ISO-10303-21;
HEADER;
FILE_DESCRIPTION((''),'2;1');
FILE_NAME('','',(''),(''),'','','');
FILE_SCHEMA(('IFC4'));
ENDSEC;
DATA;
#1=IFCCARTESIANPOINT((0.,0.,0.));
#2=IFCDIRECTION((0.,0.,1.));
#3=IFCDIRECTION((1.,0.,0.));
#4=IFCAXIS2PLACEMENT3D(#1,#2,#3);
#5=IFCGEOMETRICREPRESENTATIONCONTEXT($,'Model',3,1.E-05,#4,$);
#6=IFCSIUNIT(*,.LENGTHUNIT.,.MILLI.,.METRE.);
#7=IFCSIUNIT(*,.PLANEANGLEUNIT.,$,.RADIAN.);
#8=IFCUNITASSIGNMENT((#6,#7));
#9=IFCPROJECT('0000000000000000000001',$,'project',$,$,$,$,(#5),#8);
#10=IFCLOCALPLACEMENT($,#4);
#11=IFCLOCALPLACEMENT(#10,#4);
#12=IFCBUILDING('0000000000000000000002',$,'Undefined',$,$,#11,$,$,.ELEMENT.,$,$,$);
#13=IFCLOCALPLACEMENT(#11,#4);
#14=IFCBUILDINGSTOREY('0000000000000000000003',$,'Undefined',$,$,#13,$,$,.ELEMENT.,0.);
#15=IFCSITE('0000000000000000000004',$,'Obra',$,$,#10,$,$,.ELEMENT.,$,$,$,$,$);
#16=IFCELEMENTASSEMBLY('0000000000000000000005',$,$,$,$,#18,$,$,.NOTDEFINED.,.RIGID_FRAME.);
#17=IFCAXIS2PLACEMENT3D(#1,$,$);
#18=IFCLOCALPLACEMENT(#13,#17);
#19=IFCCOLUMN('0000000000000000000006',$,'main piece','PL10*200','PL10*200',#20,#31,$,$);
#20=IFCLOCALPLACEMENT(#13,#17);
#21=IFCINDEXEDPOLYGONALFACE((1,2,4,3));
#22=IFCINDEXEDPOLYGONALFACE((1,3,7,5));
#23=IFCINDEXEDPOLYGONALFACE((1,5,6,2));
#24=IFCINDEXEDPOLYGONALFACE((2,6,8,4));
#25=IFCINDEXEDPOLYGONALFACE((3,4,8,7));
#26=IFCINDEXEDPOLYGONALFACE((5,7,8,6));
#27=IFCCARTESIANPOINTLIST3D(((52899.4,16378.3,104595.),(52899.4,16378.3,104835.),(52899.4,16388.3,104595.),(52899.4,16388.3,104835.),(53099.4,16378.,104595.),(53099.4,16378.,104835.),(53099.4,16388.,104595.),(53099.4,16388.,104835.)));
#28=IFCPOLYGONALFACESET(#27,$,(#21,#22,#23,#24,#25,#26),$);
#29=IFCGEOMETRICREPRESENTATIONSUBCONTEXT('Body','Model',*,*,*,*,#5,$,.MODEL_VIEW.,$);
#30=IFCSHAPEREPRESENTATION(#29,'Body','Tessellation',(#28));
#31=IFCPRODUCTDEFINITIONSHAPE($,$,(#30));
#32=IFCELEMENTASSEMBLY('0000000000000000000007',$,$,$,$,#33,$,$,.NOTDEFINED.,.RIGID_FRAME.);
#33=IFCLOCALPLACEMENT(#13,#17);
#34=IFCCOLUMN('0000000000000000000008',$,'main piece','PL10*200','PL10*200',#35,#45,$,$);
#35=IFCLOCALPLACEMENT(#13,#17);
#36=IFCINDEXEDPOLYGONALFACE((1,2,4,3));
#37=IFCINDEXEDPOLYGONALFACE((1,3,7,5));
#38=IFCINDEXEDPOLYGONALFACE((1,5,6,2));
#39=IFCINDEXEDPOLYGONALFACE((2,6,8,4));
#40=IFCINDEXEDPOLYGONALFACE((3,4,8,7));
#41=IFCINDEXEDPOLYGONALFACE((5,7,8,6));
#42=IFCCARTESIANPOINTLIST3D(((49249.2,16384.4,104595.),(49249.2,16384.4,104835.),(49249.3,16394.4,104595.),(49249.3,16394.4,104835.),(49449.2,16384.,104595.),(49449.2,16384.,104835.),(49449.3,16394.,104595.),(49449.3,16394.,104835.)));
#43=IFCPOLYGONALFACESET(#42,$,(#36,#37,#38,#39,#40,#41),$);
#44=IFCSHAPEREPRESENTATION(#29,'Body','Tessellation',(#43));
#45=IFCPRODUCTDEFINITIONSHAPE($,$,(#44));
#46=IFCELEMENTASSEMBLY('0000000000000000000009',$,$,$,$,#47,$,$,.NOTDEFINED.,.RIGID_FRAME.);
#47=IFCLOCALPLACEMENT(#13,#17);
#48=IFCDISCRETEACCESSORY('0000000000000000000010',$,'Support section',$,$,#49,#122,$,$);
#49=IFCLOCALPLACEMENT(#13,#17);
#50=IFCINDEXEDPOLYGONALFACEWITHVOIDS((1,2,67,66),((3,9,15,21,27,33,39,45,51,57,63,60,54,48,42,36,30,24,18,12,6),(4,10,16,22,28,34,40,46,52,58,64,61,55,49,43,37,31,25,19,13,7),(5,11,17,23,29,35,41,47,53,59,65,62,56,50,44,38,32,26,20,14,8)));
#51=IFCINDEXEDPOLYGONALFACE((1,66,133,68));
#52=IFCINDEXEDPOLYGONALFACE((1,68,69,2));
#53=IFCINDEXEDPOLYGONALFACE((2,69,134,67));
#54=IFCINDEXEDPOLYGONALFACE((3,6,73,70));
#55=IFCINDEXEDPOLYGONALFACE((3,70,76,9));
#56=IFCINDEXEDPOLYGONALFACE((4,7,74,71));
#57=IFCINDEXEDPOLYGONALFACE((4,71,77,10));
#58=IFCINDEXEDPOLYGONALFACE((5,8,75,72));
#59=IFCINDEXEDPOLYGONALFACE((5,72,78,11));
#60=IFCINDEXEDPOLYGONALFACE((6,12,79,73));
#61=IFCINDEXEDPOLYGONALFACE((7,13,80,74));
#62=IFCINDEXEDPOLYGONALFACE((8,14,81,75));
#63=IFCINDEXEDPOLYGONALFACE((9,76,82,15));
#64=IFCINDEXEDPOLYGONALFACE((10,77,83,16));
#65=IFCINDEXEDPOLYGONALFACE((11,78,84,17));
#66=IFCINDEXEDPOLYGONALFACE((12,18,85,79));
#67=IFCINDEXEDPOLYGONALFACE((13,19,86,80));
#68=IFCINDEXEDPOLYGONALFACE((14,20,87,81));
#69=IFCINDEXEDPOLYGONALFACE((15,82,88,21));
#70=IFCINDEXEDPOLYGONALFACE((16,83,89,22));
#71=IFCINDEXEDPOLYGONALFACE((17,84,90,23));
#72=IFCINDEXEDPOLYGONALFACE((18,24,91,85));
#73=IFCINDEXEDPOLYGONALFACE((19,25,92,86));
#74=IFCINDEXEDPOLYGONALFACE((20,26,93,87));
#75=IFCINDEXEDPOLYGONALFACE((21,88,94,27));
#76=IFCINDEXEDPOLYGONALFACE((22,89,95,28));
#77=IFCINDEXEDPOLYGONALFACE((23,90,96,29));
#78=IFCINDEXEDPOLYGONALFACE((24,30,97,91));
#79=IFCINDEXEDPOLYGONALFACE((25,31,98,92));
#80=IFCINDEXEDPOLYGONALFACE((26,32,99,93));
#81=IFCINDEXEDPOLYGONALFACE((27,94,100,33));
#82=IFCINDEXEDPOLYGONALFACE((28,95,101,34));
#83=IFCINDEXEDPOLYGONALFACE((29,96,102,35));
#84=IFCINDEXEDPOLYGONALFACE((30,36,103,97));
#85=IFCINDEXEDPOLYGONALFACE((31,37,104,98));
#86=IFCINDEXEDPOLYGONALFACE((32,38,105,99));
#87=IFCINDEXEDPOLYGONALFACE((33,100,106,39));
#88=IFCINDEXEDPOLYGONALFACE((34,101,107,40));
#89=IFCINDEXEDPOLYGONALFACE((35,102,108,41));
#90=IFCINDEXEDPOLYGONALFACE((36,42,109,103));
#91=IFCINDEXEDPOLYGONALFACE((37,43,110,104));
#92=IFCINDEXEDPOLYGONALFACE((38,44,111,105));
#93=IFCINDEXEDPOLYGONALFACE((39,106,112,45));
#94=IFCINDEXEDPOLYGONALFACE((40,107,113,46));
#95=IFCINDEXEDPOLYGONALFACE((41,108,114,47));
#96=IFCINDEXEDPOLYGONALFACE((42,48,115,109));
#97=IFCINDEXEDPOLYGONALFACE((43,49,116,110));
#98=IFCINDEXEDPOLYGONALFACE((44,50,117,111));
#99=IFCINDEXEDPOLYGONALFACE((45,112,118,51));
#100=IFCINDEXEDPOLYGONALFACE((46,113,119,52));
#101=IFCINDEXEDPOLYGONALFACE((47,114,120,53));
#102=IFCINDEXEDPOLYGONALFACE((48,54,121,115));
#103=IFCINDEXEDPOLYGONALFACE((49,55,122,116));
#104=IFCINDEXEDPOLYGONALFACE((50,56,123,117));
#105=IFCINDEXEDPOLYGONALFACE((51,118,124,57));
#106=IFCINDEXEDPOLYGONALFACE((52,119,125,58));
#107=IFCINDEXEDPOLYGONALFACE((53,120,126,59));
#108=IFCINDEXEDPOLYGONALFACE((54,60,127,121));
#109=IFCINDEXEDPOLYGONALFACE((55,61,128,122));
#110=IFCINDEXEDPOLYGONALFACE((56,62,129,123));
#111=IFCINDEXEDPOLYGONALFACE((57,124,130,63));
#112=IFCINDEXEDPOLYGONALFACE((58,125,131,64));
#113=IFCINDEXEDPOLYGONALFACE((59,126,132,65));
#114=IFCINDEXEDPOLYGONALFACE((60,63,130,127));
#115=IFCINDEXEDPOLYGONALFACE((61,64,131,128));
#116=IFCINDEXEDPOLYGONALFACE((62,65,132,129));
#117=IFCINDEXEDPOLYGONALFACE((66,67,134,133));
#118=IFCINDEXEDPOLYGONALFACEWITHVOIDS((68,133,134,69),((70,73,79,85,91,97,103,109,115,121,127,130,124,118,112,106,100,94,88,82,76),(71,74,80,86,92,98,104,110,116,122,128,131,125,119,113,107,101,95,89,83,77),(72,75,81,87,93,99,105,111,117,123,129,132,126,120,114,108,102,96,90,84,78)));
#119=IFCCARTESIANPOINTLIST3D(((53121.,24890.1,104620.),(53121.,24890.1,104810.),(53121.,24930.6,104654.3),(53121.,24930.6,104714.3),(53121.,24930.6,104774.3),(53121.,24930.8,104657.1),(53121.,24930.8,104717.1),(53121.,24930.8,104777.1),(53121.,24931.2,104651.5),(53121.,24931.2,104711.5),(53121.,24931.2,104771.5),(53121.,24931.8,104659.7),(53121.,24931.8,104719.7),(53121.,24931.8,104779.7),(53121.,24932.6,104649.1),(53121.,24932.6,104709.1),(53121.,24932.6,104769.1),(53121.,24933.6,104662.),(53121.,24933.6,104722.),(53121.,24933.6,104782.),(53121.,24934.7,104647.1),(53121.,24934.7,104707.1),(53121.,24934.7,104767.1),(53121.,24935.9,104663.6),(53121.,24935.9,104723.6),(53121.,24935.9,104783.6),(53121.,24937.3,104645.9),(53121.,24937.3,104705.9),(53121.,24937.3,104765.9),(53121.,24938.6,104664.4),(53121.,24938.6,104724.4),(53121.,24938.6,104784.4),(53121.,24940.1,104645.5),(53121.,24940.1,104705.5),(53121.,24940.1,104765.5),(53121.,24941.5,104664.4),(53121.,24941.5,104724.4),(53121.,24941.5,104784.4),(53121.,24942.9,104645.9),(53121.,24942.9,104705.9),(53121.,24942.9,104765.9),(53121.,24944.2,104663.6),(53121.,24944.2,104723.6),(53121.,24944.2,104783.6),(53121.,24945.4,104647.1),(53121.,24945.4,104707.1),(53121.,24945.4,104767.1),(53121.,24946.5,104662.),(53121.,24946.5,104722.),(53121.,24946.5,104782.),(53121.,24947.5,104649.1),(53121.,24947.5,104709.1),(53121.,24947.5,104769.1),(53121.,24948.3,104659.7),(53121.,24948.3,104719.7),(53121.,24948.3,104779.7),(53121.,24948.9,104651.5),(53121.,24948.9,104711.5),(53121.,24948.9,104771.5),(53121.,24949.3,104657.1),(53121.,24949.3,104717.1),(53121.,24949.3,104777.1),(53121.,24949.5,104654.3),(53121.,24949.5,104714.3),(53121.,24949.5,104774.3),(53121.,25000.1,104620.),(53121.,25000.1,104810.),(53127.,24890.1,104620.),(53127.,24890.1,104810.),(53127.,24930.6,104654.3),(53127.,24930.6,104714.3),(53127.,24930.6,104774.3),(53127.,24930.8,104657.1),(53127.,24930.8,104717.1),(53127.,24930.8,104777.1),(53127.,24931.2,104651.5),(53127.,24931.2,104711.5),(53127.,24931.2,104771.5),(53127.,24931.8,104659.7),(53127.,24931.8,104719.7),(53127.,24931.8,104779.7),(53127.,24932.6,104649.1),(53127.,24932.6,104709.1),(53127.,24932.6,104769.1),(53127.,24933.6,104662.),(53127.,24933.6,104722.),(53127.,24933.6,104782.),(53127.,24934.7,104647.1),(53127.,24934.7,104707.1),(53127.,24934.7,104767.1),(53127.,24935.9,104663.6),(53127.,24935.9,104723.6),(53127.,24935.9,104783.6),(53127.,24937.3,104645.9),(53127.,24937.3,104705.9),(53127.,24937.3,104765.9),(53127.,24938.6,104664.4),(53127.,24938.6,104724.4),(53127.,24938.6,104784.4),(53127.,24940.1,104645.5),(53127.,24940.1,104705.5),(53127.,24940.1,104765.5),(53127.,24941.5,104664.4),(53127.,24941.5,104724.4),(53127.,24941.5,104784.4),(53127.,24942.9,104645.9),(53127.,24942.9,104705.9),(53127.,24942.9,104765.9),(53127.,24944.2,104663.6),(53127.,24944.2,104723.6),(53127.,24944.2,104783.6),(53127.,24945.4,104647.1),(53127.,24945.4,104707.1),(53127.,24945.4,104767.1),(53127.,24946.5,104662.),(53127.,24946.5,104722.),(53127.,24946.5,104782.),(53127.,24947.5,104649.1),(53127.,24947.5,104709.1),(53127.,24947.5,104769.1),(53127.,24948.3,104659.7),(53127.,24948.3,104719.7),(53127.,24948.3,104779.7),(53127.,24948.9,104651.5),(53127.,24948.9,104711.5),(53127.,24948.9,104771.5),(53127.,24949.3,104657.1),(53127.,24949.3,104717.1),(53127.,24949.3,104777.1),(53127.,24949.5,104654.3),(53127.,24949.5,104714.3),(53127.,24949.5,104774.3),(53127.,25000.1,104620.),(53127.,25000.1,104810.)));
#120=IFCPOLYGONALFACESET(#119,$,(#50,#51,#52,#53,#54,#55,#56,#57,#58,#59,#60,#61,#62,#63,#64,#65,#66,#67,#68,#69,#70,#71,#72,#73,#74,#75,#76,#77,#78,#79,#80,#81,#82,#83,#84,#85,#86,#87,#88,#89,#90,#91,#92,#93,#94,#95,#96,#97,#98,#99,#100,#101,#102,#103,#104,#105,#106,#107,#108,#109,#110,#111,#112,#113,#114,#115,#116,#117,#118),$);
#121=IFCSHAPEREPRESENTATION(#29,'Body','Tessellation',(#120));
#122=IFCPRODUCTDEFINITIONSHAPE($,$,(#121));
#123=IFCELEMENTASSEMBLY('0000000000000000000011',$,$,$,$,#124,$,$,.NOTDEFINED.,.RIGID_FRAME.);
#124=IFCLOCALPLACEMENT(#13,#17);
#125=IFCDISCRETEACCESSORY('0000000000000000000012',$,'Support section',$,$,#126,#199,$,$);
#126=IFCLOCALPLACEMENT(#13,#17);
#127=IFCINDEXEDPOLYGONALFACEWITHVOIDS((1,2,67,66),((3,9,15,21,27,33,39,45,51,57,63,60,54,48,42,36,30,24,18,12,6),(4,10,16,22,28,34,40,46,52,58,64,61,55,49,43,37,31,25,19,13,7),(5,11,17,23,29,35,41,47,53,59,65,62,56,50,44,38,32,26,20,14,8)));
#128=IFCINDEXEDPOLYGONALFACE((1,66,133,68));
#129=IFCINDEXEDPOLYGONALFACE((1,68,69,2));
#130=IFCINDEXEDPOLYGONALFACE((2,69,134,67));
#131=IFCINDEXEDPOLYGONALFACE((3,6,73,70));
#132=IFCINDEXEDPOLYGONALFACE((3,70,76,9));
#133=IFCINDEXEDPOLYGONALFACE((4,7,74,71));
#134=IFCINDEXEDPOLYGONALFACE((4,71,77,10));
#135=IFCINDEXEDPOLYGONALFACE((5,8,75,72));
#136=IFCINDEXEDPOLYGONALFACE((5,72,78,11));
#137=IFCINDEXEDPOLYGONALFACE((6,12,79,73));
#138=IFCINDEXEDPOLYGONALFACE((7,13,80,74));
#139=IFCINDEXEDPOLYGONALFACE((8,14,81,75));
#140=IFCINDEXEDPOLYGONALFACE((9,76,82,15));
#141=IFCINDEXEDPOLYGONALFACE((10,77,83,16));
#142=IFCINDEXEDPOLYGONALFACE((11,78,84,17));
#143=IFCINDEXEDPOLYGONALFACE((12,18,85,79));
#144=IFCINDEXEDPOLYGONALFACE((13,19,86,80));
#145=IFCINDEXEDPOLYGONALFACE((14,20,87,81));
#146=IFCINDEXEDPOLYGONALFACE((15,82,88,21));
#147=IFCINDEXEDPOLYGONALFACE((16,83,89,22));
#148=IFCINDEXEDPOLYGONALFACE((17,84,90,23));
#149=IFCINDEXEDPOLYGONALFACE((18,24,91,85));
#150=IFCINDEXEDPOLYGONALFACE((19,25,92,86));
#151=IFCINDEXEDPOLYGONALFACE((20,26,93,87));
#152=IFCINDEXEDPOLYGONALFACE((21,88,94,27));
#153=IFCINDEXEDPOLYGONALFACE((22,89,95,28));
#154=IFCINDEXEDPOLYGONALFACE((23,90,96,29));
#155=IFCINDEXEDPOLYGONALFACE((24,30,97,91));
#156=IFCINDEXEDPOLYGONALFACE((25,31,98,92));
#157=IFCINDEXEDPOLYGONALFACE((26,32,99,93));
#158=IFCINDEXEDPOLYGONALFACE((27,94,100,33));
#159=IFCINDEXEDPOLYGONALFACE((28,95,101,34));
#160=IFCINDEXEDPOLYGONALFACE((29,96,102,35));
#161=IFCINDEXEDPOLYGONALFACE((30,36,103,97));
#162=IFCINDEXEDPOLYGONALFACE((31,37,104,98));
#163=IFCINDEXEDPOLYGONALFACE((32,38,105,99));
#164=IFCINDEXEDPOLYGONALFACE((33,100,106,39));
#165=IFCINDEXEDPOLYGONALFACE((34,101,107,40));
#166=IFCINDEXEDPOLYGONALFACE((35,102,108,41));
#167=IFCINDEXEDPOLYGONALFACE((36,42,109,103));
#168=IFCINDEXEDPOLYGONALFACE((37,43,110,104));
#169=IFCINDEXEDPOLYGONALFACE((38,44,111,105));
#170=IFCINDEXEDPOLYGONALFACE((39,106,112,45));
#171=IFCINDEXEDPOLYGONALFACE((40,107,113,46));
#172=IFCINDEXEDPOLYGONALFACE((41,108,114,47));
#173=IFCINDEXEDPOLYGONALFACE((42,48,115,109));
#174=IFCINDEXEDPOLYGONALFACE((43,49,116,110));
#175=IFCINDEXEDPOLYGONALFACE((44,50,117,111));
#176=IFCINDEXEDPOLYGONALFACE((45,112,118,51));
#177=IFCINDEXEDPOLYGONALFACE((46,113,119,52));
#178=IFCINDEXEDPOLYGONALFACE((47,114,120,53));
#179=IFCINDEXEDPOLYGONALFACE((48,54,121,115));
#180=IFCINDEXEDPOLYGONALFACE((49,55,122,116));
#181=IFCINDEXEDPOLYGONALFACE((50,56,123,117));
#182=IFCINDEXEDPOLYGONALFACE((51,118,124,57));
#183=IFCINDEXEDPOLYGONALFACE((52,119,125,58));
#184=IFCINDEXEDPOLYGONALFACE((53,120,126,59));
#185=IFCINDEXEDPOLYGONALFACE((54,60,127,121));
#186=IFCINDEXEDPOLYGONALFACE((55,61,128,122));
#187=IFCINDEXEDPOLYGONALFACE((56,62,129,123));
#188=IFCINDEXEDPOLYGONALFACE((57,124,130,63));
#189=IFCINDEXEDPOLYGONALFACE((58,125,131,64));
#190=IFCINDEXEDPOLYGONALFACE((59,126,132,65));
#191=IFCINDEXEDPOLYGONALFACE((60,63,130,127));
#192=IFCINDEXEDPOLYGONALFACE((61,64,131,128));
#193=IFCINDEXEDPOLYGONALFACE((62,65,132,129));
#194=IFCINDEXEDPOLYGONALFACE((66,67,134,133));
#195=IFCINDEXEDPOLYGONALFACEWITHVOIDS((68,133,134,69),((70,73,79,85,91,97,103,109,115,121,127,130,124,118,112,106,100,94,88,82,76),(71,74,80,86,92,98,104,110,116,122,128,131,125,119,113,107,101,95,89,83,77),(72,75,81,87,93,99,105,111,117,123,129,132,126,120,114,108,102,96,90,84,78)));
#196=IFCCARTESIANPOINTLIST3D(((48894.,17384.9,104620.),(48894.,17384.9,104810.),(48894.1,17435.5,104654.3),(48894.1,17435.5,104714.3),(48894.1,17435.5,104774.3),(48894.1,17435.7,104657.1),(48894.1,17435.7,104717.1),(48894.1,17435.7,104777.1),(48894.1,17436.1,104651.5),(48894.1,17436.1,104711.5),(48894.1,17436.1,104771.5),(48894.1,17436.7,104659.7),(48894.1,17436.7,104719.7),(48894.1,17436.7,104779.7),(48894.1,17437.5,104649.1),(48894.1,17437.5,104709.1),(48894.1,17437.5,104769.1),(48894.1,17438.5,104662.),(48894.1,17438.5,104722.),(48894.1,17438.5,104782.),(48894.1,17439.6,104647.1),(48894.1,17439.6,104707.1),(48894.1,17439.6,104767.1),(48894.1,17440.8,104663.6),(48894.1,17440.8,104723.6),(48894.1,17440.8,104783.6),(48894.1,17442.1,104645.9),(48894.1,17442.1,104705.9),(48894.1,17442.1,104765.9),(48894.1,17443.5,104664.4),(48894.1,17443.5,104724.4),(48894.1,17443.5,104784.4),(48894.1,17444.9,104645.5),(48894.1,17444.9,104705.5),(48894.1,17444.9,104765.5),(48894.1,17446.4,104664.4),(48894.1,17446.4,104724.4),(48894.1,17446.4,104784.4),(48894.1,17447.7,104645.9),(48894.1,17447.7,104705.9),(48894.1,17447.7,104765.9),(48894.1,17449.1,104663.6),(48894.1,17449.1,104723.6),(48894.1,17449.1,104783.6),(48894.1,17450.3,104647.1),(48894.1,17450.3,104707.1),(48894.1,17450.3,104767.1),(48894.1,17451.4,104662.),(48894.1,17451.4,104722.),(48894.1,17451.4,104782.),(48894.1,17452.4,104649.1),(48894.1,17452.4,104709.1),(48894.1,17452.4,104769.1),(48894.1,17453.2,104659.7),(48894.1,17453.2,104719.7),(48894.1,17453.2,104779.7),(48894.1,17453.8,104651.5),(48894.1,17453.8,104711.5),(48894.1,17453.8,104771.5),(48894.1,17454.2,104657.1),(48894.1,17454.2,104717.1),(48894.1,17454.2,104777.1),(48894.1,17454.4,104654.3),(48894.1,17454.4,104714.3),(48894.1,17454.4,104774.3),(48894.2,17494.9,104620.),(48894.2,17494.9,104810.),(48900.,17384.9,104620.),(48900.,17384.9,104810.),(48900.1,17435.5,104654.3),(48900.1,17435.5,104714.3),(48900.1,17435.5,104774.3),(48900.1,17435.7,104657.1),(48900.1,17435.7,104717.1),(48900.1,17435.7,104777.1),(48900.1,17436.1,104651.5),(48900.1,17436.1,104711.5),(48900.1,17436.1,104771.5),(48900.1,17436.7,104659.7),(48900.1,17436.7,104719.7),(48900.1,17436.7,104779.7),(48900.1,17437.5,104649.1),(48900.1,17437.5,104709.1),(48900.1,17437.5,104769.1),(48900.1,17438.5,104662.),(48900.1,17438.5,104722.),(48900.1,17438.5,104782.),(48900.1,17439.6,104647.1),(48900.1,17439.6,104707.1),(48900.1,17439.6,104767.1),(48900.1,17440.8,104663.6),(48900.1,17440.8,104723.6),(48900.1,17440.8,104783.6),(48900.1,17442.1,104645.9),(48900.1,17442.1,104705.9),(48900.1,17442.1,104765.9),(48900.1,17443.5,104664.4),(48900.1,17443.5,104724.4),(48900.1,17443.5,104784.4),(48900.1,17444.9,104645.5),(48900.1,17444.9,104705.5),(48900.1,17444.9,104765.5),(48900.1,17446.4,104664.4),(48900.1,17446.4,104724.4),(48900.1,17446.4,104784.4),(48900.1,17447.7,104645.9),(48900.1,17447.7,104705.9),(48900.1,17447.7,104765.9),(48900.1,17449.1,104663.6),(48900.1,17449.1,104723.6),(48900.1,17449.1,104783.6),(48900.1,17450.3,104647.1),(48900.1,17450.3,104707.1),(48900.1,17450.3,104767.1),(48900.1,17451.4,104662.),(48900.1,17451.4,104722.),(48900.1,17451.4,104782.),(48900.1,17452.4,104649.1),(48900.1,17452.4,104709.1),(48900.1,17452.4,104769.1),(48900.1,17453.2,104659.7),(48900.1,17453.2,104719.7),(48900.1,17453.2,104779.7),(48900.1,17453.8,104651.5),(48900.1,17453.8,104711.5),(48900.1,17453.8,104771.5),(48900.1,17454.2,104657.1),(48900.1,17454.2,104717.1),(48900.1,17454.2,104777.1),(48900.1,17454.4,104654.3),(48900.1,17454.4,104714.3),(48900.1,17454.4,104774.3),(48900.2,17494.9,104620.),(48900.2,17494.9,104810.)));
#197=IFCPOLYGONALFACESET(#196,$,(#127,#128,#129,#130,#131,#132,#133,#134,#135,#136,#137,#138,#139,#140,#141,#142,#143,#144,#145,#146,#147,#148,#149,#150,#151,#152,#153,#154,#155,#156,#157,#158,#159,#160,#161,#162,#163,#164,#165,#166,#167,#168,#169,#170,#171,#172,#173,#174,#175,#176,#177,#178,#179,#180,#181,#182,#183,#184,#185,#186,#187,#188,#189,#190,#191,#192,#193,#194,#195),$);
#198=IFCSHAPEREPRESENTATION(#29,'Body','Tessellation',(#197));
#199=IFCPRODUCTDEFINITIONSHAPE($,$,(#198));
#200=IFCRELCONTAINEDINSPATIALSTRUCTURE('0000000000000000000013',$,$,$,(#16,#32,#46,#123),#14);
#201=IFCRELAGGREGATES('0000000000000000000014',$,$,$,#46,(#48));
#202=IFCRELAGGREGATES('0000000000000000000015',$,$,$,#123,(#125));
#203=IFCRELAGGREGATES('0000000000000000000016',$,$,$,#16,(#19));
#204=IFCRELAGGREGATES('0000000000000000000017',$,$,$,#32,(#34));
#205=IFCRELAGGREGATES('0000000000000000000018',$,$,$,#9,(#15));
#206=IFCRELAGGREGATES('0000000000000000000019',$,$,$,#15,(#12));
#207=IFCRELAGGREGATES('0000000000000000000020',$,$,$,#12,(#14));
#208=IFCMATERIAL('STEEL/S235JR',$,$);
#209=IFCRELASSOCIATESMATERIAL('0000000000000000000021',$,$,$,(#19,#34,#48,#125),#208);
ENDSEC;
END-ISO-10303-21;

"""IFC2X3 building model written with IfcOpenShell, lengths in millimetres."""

from ifc_helpers import new_model, si_unit, frame, origin_with_axes, origin_2d_with_axis, place, context, subcontext, project, spatial, rectangle, circle, extrude, source, transform, mapped, material, element, aggregate, save


model = new_model("IFC2X3")

# Units and contexts
model_context = context("Model", 3, precision=1e-05, world=origin_with_axes())
body_context = subcontext(model_context, "Body", "Model", "MODEL_VIEW")
ifc_project = project(units=[si_unit("LENGTHUNIT", "METRE", prefix="MILLI"), si_unit("PLANEANGLEUNIT", "RADIAN")], contexts=[model_context])

# Site, building, storey
site_placement = place(None, origin_with_axes())
site = spatial("IfcSite", under=ifc_project, at=site_placement, Name="Obra", CompositionType="ELEMENT")
building_placement = place(site_placement, origin_with_axes())
building = spatial("IfcBuilding", under=site, at=building_placement, Name="Undefined", CompositionType="ELEMENT")
storey_placement = place(building_placement, origin_with_axes())
storey = spatial("IfcBuildingStorey", under=building, at=storey_placement, Name="Undefined", CompositionType="ELEMENT", Elevation=0.0)

# Element assemblies, columns
assembly_1_placement = place(storey_placement, origin_with_axes())
assembly_1 = element("IfcElementAssembly", 1, at=assembly_1_placement, inside=storey, AssemblyPlace="NOTDEFINED", PredefinedType="RIGID_FRAME")
ifc_material = material(Name="STEEL/S235JR")
column_1_placement = place(assembly_1_placement, frame((52999.4, 16383.2, 104595.0), z_axis=(0.0, 0.0, 1.0), x_axis=(-0.999999, 0.001649, 0.0)))
column_1 = element("IfcColumn", 2, at=column_1_placement, material=ifc_material, Name="main piece", Description="PL10*200", ObjectType="PL10*200", context=body_context, shape_type="SweptSolid", body=[
    extrude(rectangle(XDim=10.0, YDim=200.0, at=origin_2d_with_axis()), frame((0.0, 0.0, 240.0), z_axis=(0.0, 0.0, -1.0), x_axis=(0.0, 1.0, 0.0)), (0.0, 0.0, 1.0), 240.0),
])
assembly_2_placement = place(storey_placement, origin_with_axes())
assembly_2 = element("IfcElementAssembly", 3, at=assembly_2_placement, inside=storey, AssemblyPlace="NOTDEFINED", PredefinedType="RIGID_FRAME")
column_2_placement = place(assembly_2_placement, frame((49349.3, 16389.2, 104595.0), z_axis=(0.0, 0.0, 1.0), x_axis=(-0.999999, 0.001649, 0.0)))
column_2 = element("IfcColumn", 4, at=column_2_placement, material=ifc_material, Name="main piece", Description="PL10*200", ObjectType="PL10*200", context=body_context, shape_type="SweptSolid", body=[
    extrude(rectangle(XDim=10.0, YDim=200.0, at=origin_2d_with_axis()), frame((0.0, 0.0, 240.0), z_axis=(0.0, 0.0, -1.0), x_axis=(0.0, 1.0, 0.0)), (0.0, 0.0, 1.0), 240.0),
])

# Element assemblies, discrete accessories, openings
assembly_3_placement = place(storey_placement, origin_with_axes())
assembly_3 = element("IfcElementAssembly", 5, at=assembly_3_placement, inside=storey, AssemblyPlace="NOTDEFINED", PredefinedType="RIGID_FRAME")
discrete_accessory_1_placement = place(assembly_3_placement, frame((53124.0, 24945.1, 104620.0), z_axis=(0.0, 0.0, 1.0), x_axis=(-0.000002, 1.0, 0.0)))
discrete_accessory_1 = element("IfcDiscreteAccessory", 6, at=discrete_accessory_1_placement, material=ifc_material, Name="Support section", context=body_context, shape_type="SweptSolid", body=[
    extrude(rectangle(XDim=6.0, YDim=110.0, at=origin_2d_with_axis()), frame((0.0, 0.0, 190.0), z_axis=(0.0, 0.0, -1.0), x_axis=(0.0, 1.0, 0.0)), (0.0, 0.0, 1.0), 190.0),
])
shared_shape_1 = source(origin_with_axes(), body_context, "Body", "SweptSolid", [
    extrude(circle(Radius=9.5, at=origin_2d_with_axis()), frame((0.0, -9.2, 0.0), z_axis=(0.0, 1.0, 0.0), x_axis=(1.0, 0.0, 0.0)), (0.0, 0.0, 1.0), 6.2),
])
opening_1_placement = place(assembly_3_placement, frame((53130.1, 24990.1, 104835.0), z_axis=(0.000002, -1.0, 0.0), x_axis=(0.0, 0.0, -1.0)))
element("IfcOpeningElement", 7, at=opening_1_placement, cuts=discrete_accessory_1, ObjectType="Opening", context=body_context, shape_type="MappedRepresentation", body=[
    mapped(shared_shape_1, transform((60.0, 0.0, 50.0))),
    mapped(shared_shape_1, transform((120.0, 0.0, 50.0))),
    mapped(shared_shape_1, transform((180.0, 0.0, 50.0))),
])
aggregate(assembly_3, [discrete_accessory_1])
assembly_4_placement = place(storey_placement, origin_with_axes())
assembly_4 = element("IfcElementAssembly", 8, at=assembly_4_placement, inside=storey, AssemblyPlace="NOTDEFINED", PredefinedType="RIGID_FRAME")
discrete_accessory_2_placement = place(assembly_4_placement, frame((48897.1, 17439.9, 104620.0), z_axis=(0.0, 0.0, 1.0), x_axis=(-0.001649, -0.999999, 0.0)))
discrete_accessory_2 = element("IfcDiscreteAccessory", 9, at=discrete_accessory_2_placement, material=ifc_material, Name="Support section", context=body_context, shape_type="SweptSolid", body=[
    extrude(rectangle(XDim=6.0, YDim=110.0, at=origin_2d_with_axis()), frame((0.0, 0.0, 190.0), z_axis=(0.0, 0.0, -1.0), x_axis=(0.0, 1.0, 0.0)), (0.0, 0.0, 1.0), 190.0),
])
opening_2_placement = place(assembly_4_placement, frame((48890.9, 17395.0, 104835.0), z_axis=(0.001649, 0.999999, 0.0), x_axis=(0.0, 0.0, -1.0)))
element("IfcOpeningElement", 10, at=opening_2_placement, cuts=discrete_accessory_2, ObjectType="Opening", context=body_context, shape_type="MappedRepresentation", body=[
    mapped(shared_shape_1, transform((60.0, 0.0, 50.0))),
    mapped(shared_shape_1, transform((120.0, 0.0, 50.0))),
    mapped(shared_shape_1, transform((180.0, 0.0, 50.0))),
])
aggregate(assembly_4, [discrete_accessory_2])

aggregate(assembly_1, [column_1])
aggregate(assembly_2, [column_2])

save(model, "model.ifc")
